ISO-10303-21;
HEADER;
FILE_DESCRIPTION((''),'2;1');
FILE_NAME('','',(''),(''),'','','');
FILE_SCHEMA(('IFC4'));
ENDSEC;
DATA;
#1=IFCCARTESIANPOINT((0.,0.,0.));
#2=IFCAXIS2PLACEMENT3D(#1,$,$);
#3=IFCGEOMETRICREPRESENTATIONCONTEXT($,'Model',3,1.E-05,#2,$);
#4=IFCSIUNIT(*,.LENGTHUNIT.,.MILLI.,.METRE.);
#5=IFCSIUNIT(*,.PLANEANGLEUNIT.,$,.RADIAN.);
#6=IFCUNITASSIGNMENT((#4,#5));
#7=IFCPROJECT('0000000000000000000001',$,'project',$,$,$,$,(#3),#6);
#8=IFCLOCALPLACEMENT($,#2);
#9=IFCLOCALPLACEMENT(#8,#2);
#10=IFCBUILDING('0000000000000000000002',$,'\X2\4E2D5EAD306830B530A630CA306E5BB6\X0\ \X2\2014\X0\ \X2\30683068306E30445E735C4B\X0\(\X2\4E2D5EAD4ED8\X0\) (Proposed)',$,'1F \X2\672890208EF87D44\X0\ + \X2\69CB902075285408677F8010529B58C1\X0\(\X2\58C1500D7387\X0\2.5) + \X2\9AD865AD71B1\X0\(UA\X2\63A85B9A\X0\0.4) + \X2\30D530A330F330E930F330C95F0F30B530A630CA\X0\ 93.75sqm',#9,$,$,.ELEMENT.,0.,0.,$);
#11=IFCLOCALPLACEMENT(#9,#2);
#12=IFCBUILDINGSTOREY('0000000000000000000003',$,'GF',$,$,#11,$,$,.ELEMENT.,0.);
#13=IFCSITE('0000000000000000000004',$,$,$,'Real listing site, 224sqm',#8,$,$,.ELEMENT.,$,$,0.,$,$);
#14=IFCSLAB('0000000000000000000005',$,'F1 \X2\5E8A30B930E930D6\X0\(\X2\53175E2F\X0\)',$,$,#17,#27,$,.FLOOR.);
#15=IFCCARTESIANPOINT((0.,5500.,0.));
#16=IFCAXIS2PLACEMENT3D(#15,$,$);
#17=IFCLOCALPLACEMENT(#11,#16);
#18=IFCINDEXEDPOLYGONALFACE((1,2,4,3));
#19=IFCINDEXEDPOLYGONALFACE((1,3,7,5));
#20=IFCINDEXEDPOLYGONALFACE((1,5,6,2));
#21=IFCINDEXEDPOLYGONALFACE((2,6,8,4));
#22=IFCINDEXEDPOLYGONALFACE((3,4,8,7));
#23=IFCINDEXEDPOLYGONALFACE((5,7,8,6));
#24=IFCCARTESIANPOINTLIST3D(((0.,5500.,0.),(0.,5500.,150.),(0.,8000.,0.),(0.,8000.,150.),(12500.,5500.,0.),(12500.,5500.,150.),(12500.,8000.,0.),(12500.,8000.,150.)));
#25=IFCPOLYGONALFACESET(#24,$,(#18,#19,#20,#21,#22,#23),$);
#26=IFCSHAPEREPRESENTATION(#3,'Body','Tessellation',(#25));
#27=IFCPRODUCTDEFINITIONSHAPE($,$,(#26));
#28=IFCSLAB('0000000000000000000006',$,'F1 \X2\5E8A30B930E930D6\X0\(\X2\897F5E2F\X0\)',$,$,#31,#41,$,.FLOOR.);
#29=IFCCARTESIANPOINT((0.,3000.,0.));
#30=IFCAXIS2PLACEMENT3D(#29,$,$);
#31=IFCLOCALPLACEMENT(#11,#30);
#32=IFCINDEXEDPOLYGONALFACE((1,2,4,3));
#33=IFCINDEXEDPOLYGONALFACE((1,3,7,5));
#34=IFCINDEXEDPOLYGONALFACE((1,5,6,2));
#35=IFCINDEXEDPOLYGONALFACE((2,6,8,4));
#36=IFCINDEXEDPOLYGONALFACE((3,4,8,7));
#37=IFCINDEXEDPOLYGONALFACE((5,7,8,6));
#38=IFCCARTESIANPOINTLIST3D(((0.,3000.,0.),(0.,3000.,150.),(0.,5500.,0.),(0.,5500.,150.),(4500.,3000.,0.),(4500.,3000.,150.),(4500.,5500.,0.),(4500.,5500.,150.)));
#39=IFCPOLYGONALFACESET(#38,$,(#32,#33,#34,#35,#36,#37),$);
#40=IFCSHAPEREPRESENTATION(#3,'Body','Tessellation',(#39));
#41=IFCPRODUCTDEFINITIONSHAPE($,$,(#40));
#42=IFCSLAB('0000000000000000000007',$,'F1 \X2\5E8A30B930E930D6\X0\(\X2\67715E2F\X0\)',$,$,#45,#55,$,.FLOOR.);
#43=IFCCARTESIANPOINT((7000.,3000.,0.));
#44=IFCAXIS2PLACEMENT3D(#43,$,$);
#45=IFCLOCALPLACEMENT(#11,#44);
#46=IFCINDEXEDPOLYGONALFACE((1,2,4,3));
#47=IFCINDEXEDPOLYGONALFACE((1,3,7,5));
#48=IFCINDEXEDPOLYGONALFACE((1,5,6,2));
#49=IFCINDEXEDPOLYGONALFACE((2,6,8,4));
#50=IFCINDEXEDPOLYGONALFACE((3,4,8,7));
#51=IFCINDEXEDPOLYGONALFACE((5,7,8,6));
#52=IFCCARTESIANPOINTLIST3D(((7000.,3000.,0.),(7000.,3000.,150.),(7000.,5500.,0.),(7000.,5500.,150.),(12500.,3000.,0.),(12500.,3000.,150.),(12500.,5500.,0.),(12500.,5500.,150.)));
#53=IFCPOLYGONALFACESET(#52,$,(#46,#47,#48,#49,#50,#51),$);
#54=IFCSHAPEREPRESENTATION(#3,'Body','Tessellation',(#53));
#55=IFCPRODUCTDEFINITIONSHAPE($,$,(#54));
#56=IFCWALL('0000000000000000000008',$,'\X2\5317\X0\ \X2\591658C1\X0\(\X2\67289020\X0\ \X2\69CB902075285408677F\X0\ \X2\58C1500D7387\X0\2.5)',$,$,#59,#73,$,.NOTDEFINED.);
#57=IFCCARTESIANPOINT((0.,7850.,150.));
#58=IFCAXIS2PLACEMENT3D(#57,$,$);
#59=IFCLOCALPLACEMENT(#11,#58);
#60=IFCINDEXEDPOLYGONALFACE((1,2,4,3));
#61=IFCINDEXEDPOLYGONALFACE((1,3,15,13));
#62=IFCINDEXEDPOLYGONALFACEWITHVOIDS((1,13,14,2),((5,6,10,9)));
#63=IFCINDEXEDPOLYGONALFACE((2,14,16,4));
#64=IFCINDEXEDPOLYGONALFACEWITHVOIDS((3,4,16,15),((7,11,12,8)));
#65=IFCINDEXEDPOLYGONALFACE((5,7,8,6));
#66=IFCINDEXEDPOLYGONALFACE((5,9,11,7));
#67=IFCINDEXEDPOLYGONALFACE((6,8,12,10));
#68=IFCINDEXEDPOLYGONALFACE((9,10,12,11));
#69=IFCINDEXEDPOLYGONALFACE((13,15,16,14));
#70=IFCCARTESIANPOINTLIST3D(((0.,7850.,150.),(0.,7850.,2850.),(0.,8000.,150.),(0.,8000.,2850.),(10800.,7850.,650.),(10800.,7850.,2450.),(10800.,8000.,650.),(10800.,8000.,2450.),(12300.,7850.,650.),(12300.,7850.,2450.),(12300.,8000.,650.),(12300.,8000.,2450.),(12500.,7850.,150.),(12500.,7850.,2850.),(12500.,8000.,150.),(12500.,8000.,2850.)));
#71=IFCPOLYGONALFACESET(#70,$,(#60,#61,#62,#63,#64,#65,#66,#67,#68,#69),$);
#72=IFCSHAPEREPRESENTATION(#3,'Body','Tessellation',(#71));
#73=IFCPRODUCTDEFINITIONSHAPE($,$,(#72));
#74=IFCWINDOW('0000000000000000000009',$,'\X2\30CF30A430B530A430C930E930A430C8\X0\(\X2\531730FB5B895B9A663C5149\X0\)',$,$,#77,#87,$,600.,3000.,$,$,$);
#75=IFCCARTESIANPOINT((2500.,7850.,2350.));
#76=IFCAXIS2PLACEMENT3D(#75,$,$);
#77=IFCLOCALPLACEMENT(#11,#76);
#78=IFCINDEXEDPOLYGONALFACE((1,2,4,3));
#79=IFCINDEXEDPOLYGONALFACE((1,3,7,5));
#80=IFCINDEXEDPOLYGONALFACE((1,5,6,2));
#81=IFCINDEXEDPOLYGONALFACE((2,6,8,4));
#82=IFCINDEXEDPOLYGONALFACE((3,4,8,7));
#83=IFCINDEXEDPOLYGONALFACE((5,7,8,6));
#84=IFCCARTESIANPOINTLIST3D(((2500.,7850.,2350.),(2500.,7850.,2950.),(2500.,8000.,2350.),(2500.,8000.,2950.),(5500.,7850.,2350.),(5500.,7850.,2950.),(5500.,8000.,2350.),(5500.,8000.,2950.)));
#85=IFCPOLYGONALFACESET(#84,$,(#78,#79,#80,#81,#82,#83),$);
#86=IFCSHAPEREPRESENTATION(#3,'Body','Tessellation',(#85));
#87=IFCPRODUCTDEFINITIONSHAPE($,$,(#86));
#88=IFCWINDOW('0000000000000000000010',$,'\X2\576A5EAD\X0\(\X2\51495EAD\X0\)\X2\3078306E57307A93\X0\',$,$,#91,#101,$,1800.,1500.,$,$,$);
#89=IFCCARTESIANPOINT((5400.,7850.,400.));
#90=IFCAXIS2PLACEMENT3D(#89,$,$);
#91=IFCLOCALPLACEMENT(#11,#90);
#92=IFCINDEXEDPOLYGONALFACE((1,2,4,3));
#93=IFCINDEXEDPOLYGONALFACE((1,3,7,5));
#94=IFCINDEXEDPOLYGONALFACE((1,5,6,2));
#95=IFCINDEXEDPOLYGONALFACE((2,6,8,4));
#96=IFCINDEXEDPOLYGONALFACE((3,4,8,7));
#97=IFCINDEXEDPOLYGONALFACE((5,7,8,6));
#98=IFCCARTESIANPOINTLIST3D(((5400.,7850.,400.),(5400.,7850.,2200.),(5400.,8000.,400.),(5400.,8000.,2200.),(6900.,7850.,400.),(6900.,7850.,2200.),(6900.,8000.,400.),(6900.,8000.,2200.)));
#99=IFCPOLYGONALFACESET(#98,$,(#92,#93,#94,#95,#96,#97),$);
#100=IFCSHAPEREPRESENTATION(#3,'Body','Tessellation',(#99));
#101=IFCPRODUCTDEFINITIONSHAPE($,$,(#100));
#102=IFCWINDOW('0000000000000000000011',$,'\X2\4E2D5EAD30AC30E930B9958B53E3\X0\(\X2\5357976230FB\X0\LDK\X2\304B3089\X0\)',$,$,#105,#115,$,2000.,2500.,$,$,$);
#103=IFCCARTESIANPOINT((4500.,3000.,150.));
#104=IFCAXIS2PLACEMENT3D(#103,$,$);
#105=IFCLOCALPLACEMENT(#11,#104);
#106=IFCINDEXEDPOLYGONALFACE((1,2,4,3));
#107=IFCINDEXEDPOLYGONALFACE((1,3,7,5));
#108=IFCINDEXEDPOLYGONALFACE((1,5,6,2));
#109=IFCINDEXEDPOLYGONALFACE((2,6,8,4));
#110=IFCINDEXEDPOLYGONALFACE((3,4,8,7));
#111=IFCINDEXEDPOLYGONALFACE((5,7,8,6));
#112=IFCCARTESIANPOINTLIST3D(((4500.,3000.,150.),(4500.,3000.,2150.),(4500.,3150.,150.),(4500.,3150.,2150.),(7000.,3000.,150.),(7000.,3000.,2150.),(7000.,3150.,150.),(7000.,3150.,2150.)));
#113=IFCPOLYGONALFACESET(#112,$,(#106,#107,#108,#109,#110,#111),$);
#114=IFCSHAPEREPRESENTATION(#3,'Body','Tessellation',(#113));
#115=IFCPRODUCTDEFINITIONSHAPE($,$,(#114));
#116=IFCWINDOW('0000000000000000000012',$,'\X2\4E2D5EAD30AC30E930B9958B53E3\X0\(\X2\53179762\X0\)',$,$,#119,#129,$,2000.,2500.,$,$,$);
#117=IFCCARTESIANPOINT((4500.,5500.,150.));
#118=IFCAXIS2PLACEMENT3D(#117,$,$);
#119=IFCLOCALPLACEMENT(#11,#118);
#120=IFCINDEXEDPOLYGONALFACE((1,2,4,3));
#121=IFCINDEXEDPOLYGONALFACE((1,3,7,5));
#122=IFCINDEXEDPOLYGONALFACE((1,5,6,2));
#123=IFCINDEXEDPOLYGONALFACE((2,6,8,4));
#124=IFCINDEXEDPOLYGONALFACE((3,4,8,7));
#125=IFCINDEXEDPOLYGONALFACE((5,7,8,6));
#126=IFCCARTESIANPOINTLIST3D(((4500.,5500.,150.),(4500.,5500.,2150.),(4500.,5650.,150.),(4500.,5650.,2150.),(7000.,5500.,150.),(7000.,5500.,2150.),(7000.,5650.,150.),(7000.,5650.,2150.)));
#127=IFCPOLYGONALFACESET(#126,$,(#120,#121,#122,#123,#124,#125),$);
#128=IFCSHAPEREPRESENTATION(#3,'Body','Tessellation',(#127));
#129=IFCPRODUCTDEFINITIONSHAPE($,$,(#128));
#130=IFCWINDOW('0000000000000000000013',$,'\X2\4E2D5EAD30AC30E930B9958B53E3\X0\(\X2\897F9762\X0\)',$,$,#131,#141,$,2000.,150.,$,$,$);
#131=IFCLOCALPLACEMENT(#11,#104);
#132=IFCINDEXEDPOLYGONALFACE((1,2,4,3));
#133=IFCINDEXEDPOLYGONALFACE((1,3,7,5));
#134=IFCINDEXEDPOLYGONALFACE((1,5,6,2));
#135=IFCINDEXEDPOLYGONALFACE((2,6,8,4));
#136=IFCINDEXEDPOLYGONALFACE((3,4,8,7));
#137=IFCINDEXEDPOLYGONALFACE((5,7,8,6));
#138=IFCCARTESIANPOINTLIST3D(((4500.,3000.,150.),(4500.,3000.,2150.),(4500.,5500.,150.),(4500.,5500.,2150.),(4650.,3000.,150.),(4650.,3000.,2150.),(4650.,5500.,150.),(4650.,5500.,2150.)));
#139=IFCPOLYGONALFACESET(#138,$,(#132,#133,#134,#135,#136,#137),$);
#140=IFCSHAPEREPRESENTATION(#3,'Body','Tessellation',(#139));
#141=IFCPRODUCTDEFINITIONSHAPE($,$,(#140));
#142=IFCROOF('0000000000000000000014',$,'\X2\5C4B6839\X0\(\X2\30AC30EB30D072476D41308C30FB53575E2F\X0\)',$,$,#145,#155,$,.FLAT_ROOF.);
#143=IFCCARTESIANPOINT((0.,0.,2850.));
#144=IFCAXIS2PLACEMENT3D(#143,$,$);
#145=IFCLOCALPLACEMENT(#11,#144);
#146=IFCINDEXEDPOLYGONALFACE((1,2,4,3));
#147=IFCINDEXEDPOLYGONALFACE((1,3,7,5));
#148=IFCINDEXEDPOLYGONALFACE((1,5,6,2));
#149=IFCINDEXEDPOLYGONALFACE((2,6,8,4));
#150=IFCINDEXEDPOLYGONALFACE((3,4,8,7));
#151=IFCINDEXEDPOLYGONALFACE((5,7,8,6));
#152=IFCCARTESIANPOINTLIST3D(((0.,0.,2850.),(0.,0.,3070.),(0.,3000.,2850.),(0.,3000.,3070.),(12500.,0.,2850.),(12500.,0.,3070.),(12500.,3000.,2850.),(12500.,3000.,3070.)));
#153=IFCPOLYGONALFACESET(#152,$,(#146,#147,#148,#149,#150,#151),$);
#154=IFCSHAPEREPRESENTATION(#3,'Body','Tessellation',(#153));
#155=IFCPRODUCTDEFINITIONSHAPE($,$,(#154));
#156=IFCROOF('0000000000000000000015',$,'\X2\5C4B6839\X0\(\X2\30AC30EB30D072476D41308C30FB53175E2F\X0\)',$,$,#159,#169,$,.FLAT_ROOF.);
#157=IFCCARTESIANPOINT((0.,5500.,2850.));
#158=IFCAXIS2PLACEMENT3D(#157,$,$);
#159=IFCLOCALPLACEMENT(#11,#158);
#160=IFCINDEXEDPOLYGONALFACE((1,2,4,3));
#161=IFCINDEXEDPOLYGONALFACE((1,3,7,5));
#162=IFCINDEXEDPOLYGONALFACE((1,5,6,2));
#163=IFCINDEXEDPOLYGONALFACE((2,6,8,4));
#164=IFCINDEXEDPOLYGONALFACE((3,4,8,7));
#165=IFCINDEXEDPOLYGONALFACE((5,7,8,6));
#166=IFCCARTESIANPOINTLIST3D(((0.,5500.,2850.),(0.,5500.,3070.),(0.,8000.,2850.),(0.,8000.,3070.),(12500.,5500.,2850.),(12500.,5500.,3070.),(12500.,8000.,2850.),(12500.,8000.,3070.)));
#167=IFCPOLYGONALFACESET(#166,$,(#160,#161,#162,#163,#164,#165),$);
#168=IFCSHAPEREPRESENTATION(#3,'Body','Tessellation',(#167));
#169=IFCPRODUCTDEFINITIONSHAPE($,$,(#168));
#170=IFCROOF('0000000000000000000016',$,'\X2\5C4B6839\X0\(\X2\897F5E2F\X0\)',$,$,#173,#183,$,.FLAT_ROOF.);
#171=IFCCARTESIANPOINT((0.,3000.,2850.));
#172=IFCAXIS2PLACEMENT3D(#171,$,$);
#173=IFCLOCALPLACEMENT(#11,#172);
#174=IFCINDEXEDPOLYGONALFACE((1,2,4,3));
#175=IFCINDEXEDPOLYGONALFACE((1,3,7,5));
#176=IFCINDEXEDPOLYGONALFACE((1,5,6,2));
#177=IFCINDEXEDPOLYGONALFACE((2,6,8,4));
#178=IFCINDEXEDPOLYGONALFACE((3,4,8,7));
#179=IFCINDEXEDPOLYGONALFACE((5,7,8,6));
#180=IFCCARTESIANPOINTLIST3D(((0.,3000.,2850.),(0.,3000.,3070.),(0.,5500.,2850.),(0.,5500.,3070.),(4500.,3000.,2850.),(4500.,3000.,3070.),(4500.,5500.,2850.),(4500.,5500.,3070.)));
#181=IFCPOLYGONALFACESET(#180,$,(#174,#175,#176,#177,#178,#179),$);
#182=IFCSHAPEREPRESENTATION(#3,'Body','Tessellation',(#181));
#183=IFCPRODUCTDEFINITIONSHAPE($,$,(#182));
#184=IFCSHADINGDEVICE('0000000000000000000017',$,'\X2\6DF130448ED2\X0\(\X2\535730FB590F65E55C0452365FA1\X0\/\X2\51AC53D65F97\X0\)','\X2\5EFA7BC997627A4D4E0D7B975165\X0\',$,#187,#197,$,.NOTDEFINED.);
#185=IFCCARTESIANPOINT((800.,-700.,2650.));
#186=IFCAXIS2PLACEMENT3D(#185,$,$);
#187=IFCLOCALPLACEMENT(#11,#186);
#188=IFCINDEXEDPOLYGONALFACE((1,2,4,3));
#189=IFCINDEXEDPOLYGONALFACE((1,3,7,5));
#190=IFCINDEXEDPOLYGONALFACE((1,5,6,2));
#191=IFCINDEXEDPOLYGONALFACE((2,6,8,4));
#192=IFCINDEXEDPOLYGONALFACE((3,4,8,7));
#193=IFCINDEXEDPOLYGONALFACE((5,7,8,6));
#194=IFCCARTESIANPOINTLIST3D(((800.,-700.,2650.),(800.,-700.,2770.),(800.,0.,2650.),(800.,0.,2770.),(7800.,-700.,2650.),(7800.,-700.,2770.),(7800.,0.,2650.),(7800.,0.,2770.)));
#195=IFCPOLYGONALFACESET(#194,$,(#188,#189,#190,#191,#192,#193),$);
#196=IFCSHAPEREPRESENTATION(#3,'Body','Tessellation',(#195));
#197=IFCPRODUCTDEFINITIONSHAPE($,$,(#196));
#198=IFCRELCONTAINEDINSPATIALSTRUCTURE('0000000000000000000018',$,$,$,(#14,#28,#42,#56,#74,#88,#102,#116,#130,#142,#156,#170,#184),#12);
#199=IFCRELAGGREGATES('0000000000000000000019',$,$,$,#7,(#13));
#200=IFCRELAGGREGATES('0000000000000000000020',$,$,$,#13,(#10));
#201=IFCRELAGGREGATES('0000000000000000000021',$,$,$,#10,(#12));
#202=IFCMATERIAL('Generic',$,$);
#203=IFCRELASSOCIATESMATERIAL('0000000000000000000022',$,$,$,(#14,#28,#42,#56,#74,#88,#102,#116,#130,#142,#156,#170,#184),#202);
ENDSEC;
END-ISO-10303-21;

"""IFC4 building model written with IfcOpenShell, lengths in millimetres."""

from ifc_helpers import new_model, si_unit, frame, frame_2d, origin, place, context, project, spatial, rectangle, extrude, material, element, fill, save


model = new_model("IFC4")

# Units and contexts
model_context = context("Model", 3, precision=1e-05, world=origin())
ifc_project = project(units=[si_unit("LENGTHUNIT", "METRE", prefix="MILLI"), si_unit("PLANEANGLEUNIT", "RADIAN")], contexts=[model_context])

# Site, building, storey
site_placement = place(None, origin())
site = spatial("IfcSite", under=ifc_project, at=site_placement, ObjectType="Real listing site, 224sqm", CompositionType="ELEMENT", RefElevation=0.0)
building_placement = place(site_placement, origin())
building = spatial("IfcBuilding", under=site, at=building_placement, Name="中庭とサウナの家 — ととのい平屋(中庭付) (Proposed)", ObjectType="1F 木造軸組 + 構造用合板耐力壁(壁倍率2.5) + 高断熱(UA推定0.4) + フィンランド式サウナ 93.75sqm", CompositionType="ELEMENT", ElevationOfRefHeight=0.0, ElevationOfTerrain=0.0)
storey_placement = place(building_placement, origin())
storey = spatial("IfcBuildingStorey", under=building, at=storey_placement, Name="GF", CompositionType="ELEMENT", Elevation=0.0)

# Slabs
ifc_material = material(Name="Generic")
slab_1_placement = place(storey_placement, frame((0.0, 5500.0, 0.0)))
element("IfcSlab", 1, at=slab_1_placement, inside=storey, material=ifc_material, Name="F1 床スラブ(北帯)", PredefinedType="FLOOR", context=model_context, shape_type="SweptSolid", body=[
    extrude(rectangle(XDim=12500.0, YDim=2500.0, at=frame_2d((6250.0, 1250.0))), frame((0.0, 5500.0, 0.0)), (0.0, 0.0, 1.0), 150.0),
])
slab_2_placement = place(storey_placement, frame((0.0, 3000.0, 0.0)))
element("IfcSlab", 2, at=slab_2_placement, inside=storey, material=ifc_material, Name="F1 床スラブ(西帯)", PredefinedType="FLOOR", context=model_context, shape_type="SweptSolid", body=[
    extrude(rectangle(XDim=4500.0, YDim=2500.0, at=frame_2d((2250.0, 1250.0))), frame((0.0, 3000.0, 0.0)), (0.0, 0.0, 1.0), 150.0),
])
slab_3_placement = place(storey_placement, frame((7000.0, 3000.0, 0.0)))
element("IfcSlab", 3, at=slab_3_placement, inside=storey, material=ifc_material, Name="F1 床スラブ(東帯)", PredefinedType="FLOOR", context=model_context, shape_type="SweptSolid", body=[
    extrude(rectangle(XDim=5500.0, YDim=2500.0, at=frame_2d((2750.0, 1250.0))), frame((7000.0, 3000.0, 0.0)), (0.0, 0.0, 1.0), 150.0),
])

# Wall, openings, windows
wall_1_placement = place(storey_placement, frame((0.0, 7850.0, 150.0)))
wall_1 = element("IfcWall", 4, at=wall_1_placement, inside=storey, material=ifc_material, Name="北 外壁(木造 構造用合板 壁倍率2.5)", PredefinedType="NOTDEFINED", context=model_context, shape_type="SweptSolid", body=[
    extrude(rectangle(XDim=12500.0, YDim=150.0, at=frame_2d((6250.0, 75.0))), frame((0.0, 7850.0, 150.0)), (0.0, 0.0, 1.0), 2700.0),
])
opening_1_placement = place(storey_placement, frame((2500.0, 7850.0, 2350.0)))
opening_1 = element("IfcOpeningElement", 5, at=opening_1_placement, cuts=wall_1, PredefinedType="NOTDEFINED", context=model_context, shape_type="SweptSolid", body=[
    extrude(rectangle(XDim=3000.0, YDim=150.0, at=frame_2d((1500.0, 75.0))), frame((2500.0, 7850.0, 2350.0)), (0.0, 0.0, 1.0), 600.0),
])
opening_2_placement = place(storey_placement, frame((5400.0, 7850.0, 400.0)))
opening_2 = element("IfcOpeningElement", 6, at=opening_2_placement, cuts=wall_1, PredefinedType="NOTDEFINED", context=model_context, shape_type="SweptSolid", body=[
    extrude(rectangle(XDim=1500.0, YDim=150.0, at=frame_2d((750.0, 75.0))), frame((5400.0, 7850.0, 400.0)), (0.0, 0.0, 1.0), 1800.0),
])
window_1_placement = place(storey_placement, frame((2500.0, 7850.0, 2350.0)))
window_1 = element("IfcWindow", 7, at=window_1_placement, inside=storey, material=ifc_material, Name="ハイサイドライト(北・安定昼光)", OverallHeight=600.0, OverallWidth=3000.0, context=model_context, shape_type="SweptSolid", body=[
    extrude(rectangle(XDim=3000.0, YDim=150.0, at=frame_2d((1500.0, 75.0))), frame((2500.0, 7850.0, 2350.0)), (0.0, 0.0, 1.0), 600.0),
])
fill(opening_1, window_1)
window_2_placement = place(storey_placement, frame((5400.0, 7850.0, 400.0)))
window_2 = element("IfcWindow", 8, at=window_2_placement, inside=storey, material=ifc_material, Name="坪庭(光庭)への地窓", OverallHeight=1800.0, OverallWidth=1500.0, context=model_context, shape_type="SweptSolid", body=[
    extrude(rectangle(XDim=1500.0, YDim=150.0, at=frame_2d((750.0, 75.0))), frame((5400.0, 7850.0, 400.0)), (0.0, 0.0, 1.0), 1800.0),
])
fill(opening_2, window_2)

# Windows
window_3_placement = place(storey_placement, frame((4500.0, 3000.0, 150.0)))
element("IfcWindow", 9, at=window_3_placement, inside=storey, material=ifc_material, Name="中庭ガラス開口(南面・LDKから)", OverallHeight=2000.0, OverallWidth=2500.0, context=model_context, shape_type="SweptSolid", body=[
    extrude(rectangle(XDim=2500.0, YDim=150.0, at=frame_2d((1250.0, 75.0))), frame((4500.0, 3000.0, 150.0)), (0.0, 0.0, 1.0), 2000.0),
])
window_4_placement = place(storey_placement, frame((4500.0, 5500.0, 150.0)))
element("IfcWindow", 10, at=window_4_placement, inside=storey, material=ifc_material, Name="中庭ガラス開口(北面)", OverallHeight=2000.0, OverallWidth=2500.0, context=model_context, shape_type="SweptSolid", body=[
    extrude(rectangle(XDim=2500.0, YDim=150.0, at=frame_2d((1250.0, 75.0))), frame((4500.0, 5500.0, 150.0)), (0.0, 0.0, 1.0), 2000.0),
])
window_5_placement = place(storey_placement, frame((4500.0, 3000.0, 150.0)))
element("IfcWindow", 11, at=window_5_placement, inside=storey, material=ifc_material, Name="中庭ガラス開口(西面)", OverallHeight=2000.0, OverallWidth=150.0, context=model_context, shape_type="SweptSolid", body=[
    extrude(rectangle(XDim=150.0, YDim=2500.0, at=frame_2d((75.0, 1250.0))), frame((4500.0, 3000.0, 150.0)), (0.0, 0.0, 1.0), 2000.0),
])

# Roofs
roof_1_placement = place(storey_placement, frame((0.0, 0.0, 2850.0)))
element("IfcRoof", 12, at=roof_1_placement, inside=storey, material=ifc_material, Name="屋根(ガルバ片流れ・南帯)", PredefinedType="FLAT_ROOF", context=model_context, shape_type="SweptSolid", body=[
    extrude(rectangle(XDim=12500.0, YDim=3000.0, at=frame_2d((6250.0, 1500.0))), frame((0.0, 0.0, 2850.0)), (0.0, 0.0, 1.0), 220.0),
])
roof_2_placement = place(storey_placement, frame((0.0, 5500.0, 2850.0)))
element("IfcRoof", 13, at=roof_2_placement, inside=storey, material=ifc_material, Name="屋根(ガルバ片流れ・北帯)", PredefinedType="FLAT_ROOF", context=model_context, shape_type="SweptSolid", body=[
    extrude(rectangle(XDim=12500.0, YDim=2500.0, at=frame_2d((6250.0, 1250.0))), frame((0.0, 5500.0, 2850.0)), (0.0, 0.0, 1.0), 220.0),
])
roof_3_placement = place(storey_placement, frame((0.0, 3000.0, 2850.0)))
element("IfcRoof", 14, at=roof_3_placement, inside=storey, material=ifc_material, Name="屋根(西帯)", PredefinedType="FLAT_ROOF", context=model_context, shape_type="SweptSolid", body=[
    extrude(rectangle(XDim=4500.0, YDim=2500.0, at=frame_2d((2250.0, 1250.0))), frame((0.0, 3000.0, 2850.0)), (0.0, 0.0, 1.0), 220.0),
])

# Shading device
shading_device_placement = place(storey_placement, frame((800.0, -700.0, 2650.0)))
element("IfcShadingDevice", 15, at=shading_device_placement, inside=storey, material=ifc_material, Name="深い軒(南・夏日射制御/冬取得)", Description="建築面積不算入", PredefinedType="NOTDEFINED", context=model_context, shape_type="SweptSolid", body=[
    extrude(rectangle(XDim=7000.0, YDim=700.0, at=frame_2d((3500.0, 350.0))), frame((800.0, -700.0, 2650.0)), (0.0, 0.0, 1.0), 120.0),
])

save(model, "model.ifc")
